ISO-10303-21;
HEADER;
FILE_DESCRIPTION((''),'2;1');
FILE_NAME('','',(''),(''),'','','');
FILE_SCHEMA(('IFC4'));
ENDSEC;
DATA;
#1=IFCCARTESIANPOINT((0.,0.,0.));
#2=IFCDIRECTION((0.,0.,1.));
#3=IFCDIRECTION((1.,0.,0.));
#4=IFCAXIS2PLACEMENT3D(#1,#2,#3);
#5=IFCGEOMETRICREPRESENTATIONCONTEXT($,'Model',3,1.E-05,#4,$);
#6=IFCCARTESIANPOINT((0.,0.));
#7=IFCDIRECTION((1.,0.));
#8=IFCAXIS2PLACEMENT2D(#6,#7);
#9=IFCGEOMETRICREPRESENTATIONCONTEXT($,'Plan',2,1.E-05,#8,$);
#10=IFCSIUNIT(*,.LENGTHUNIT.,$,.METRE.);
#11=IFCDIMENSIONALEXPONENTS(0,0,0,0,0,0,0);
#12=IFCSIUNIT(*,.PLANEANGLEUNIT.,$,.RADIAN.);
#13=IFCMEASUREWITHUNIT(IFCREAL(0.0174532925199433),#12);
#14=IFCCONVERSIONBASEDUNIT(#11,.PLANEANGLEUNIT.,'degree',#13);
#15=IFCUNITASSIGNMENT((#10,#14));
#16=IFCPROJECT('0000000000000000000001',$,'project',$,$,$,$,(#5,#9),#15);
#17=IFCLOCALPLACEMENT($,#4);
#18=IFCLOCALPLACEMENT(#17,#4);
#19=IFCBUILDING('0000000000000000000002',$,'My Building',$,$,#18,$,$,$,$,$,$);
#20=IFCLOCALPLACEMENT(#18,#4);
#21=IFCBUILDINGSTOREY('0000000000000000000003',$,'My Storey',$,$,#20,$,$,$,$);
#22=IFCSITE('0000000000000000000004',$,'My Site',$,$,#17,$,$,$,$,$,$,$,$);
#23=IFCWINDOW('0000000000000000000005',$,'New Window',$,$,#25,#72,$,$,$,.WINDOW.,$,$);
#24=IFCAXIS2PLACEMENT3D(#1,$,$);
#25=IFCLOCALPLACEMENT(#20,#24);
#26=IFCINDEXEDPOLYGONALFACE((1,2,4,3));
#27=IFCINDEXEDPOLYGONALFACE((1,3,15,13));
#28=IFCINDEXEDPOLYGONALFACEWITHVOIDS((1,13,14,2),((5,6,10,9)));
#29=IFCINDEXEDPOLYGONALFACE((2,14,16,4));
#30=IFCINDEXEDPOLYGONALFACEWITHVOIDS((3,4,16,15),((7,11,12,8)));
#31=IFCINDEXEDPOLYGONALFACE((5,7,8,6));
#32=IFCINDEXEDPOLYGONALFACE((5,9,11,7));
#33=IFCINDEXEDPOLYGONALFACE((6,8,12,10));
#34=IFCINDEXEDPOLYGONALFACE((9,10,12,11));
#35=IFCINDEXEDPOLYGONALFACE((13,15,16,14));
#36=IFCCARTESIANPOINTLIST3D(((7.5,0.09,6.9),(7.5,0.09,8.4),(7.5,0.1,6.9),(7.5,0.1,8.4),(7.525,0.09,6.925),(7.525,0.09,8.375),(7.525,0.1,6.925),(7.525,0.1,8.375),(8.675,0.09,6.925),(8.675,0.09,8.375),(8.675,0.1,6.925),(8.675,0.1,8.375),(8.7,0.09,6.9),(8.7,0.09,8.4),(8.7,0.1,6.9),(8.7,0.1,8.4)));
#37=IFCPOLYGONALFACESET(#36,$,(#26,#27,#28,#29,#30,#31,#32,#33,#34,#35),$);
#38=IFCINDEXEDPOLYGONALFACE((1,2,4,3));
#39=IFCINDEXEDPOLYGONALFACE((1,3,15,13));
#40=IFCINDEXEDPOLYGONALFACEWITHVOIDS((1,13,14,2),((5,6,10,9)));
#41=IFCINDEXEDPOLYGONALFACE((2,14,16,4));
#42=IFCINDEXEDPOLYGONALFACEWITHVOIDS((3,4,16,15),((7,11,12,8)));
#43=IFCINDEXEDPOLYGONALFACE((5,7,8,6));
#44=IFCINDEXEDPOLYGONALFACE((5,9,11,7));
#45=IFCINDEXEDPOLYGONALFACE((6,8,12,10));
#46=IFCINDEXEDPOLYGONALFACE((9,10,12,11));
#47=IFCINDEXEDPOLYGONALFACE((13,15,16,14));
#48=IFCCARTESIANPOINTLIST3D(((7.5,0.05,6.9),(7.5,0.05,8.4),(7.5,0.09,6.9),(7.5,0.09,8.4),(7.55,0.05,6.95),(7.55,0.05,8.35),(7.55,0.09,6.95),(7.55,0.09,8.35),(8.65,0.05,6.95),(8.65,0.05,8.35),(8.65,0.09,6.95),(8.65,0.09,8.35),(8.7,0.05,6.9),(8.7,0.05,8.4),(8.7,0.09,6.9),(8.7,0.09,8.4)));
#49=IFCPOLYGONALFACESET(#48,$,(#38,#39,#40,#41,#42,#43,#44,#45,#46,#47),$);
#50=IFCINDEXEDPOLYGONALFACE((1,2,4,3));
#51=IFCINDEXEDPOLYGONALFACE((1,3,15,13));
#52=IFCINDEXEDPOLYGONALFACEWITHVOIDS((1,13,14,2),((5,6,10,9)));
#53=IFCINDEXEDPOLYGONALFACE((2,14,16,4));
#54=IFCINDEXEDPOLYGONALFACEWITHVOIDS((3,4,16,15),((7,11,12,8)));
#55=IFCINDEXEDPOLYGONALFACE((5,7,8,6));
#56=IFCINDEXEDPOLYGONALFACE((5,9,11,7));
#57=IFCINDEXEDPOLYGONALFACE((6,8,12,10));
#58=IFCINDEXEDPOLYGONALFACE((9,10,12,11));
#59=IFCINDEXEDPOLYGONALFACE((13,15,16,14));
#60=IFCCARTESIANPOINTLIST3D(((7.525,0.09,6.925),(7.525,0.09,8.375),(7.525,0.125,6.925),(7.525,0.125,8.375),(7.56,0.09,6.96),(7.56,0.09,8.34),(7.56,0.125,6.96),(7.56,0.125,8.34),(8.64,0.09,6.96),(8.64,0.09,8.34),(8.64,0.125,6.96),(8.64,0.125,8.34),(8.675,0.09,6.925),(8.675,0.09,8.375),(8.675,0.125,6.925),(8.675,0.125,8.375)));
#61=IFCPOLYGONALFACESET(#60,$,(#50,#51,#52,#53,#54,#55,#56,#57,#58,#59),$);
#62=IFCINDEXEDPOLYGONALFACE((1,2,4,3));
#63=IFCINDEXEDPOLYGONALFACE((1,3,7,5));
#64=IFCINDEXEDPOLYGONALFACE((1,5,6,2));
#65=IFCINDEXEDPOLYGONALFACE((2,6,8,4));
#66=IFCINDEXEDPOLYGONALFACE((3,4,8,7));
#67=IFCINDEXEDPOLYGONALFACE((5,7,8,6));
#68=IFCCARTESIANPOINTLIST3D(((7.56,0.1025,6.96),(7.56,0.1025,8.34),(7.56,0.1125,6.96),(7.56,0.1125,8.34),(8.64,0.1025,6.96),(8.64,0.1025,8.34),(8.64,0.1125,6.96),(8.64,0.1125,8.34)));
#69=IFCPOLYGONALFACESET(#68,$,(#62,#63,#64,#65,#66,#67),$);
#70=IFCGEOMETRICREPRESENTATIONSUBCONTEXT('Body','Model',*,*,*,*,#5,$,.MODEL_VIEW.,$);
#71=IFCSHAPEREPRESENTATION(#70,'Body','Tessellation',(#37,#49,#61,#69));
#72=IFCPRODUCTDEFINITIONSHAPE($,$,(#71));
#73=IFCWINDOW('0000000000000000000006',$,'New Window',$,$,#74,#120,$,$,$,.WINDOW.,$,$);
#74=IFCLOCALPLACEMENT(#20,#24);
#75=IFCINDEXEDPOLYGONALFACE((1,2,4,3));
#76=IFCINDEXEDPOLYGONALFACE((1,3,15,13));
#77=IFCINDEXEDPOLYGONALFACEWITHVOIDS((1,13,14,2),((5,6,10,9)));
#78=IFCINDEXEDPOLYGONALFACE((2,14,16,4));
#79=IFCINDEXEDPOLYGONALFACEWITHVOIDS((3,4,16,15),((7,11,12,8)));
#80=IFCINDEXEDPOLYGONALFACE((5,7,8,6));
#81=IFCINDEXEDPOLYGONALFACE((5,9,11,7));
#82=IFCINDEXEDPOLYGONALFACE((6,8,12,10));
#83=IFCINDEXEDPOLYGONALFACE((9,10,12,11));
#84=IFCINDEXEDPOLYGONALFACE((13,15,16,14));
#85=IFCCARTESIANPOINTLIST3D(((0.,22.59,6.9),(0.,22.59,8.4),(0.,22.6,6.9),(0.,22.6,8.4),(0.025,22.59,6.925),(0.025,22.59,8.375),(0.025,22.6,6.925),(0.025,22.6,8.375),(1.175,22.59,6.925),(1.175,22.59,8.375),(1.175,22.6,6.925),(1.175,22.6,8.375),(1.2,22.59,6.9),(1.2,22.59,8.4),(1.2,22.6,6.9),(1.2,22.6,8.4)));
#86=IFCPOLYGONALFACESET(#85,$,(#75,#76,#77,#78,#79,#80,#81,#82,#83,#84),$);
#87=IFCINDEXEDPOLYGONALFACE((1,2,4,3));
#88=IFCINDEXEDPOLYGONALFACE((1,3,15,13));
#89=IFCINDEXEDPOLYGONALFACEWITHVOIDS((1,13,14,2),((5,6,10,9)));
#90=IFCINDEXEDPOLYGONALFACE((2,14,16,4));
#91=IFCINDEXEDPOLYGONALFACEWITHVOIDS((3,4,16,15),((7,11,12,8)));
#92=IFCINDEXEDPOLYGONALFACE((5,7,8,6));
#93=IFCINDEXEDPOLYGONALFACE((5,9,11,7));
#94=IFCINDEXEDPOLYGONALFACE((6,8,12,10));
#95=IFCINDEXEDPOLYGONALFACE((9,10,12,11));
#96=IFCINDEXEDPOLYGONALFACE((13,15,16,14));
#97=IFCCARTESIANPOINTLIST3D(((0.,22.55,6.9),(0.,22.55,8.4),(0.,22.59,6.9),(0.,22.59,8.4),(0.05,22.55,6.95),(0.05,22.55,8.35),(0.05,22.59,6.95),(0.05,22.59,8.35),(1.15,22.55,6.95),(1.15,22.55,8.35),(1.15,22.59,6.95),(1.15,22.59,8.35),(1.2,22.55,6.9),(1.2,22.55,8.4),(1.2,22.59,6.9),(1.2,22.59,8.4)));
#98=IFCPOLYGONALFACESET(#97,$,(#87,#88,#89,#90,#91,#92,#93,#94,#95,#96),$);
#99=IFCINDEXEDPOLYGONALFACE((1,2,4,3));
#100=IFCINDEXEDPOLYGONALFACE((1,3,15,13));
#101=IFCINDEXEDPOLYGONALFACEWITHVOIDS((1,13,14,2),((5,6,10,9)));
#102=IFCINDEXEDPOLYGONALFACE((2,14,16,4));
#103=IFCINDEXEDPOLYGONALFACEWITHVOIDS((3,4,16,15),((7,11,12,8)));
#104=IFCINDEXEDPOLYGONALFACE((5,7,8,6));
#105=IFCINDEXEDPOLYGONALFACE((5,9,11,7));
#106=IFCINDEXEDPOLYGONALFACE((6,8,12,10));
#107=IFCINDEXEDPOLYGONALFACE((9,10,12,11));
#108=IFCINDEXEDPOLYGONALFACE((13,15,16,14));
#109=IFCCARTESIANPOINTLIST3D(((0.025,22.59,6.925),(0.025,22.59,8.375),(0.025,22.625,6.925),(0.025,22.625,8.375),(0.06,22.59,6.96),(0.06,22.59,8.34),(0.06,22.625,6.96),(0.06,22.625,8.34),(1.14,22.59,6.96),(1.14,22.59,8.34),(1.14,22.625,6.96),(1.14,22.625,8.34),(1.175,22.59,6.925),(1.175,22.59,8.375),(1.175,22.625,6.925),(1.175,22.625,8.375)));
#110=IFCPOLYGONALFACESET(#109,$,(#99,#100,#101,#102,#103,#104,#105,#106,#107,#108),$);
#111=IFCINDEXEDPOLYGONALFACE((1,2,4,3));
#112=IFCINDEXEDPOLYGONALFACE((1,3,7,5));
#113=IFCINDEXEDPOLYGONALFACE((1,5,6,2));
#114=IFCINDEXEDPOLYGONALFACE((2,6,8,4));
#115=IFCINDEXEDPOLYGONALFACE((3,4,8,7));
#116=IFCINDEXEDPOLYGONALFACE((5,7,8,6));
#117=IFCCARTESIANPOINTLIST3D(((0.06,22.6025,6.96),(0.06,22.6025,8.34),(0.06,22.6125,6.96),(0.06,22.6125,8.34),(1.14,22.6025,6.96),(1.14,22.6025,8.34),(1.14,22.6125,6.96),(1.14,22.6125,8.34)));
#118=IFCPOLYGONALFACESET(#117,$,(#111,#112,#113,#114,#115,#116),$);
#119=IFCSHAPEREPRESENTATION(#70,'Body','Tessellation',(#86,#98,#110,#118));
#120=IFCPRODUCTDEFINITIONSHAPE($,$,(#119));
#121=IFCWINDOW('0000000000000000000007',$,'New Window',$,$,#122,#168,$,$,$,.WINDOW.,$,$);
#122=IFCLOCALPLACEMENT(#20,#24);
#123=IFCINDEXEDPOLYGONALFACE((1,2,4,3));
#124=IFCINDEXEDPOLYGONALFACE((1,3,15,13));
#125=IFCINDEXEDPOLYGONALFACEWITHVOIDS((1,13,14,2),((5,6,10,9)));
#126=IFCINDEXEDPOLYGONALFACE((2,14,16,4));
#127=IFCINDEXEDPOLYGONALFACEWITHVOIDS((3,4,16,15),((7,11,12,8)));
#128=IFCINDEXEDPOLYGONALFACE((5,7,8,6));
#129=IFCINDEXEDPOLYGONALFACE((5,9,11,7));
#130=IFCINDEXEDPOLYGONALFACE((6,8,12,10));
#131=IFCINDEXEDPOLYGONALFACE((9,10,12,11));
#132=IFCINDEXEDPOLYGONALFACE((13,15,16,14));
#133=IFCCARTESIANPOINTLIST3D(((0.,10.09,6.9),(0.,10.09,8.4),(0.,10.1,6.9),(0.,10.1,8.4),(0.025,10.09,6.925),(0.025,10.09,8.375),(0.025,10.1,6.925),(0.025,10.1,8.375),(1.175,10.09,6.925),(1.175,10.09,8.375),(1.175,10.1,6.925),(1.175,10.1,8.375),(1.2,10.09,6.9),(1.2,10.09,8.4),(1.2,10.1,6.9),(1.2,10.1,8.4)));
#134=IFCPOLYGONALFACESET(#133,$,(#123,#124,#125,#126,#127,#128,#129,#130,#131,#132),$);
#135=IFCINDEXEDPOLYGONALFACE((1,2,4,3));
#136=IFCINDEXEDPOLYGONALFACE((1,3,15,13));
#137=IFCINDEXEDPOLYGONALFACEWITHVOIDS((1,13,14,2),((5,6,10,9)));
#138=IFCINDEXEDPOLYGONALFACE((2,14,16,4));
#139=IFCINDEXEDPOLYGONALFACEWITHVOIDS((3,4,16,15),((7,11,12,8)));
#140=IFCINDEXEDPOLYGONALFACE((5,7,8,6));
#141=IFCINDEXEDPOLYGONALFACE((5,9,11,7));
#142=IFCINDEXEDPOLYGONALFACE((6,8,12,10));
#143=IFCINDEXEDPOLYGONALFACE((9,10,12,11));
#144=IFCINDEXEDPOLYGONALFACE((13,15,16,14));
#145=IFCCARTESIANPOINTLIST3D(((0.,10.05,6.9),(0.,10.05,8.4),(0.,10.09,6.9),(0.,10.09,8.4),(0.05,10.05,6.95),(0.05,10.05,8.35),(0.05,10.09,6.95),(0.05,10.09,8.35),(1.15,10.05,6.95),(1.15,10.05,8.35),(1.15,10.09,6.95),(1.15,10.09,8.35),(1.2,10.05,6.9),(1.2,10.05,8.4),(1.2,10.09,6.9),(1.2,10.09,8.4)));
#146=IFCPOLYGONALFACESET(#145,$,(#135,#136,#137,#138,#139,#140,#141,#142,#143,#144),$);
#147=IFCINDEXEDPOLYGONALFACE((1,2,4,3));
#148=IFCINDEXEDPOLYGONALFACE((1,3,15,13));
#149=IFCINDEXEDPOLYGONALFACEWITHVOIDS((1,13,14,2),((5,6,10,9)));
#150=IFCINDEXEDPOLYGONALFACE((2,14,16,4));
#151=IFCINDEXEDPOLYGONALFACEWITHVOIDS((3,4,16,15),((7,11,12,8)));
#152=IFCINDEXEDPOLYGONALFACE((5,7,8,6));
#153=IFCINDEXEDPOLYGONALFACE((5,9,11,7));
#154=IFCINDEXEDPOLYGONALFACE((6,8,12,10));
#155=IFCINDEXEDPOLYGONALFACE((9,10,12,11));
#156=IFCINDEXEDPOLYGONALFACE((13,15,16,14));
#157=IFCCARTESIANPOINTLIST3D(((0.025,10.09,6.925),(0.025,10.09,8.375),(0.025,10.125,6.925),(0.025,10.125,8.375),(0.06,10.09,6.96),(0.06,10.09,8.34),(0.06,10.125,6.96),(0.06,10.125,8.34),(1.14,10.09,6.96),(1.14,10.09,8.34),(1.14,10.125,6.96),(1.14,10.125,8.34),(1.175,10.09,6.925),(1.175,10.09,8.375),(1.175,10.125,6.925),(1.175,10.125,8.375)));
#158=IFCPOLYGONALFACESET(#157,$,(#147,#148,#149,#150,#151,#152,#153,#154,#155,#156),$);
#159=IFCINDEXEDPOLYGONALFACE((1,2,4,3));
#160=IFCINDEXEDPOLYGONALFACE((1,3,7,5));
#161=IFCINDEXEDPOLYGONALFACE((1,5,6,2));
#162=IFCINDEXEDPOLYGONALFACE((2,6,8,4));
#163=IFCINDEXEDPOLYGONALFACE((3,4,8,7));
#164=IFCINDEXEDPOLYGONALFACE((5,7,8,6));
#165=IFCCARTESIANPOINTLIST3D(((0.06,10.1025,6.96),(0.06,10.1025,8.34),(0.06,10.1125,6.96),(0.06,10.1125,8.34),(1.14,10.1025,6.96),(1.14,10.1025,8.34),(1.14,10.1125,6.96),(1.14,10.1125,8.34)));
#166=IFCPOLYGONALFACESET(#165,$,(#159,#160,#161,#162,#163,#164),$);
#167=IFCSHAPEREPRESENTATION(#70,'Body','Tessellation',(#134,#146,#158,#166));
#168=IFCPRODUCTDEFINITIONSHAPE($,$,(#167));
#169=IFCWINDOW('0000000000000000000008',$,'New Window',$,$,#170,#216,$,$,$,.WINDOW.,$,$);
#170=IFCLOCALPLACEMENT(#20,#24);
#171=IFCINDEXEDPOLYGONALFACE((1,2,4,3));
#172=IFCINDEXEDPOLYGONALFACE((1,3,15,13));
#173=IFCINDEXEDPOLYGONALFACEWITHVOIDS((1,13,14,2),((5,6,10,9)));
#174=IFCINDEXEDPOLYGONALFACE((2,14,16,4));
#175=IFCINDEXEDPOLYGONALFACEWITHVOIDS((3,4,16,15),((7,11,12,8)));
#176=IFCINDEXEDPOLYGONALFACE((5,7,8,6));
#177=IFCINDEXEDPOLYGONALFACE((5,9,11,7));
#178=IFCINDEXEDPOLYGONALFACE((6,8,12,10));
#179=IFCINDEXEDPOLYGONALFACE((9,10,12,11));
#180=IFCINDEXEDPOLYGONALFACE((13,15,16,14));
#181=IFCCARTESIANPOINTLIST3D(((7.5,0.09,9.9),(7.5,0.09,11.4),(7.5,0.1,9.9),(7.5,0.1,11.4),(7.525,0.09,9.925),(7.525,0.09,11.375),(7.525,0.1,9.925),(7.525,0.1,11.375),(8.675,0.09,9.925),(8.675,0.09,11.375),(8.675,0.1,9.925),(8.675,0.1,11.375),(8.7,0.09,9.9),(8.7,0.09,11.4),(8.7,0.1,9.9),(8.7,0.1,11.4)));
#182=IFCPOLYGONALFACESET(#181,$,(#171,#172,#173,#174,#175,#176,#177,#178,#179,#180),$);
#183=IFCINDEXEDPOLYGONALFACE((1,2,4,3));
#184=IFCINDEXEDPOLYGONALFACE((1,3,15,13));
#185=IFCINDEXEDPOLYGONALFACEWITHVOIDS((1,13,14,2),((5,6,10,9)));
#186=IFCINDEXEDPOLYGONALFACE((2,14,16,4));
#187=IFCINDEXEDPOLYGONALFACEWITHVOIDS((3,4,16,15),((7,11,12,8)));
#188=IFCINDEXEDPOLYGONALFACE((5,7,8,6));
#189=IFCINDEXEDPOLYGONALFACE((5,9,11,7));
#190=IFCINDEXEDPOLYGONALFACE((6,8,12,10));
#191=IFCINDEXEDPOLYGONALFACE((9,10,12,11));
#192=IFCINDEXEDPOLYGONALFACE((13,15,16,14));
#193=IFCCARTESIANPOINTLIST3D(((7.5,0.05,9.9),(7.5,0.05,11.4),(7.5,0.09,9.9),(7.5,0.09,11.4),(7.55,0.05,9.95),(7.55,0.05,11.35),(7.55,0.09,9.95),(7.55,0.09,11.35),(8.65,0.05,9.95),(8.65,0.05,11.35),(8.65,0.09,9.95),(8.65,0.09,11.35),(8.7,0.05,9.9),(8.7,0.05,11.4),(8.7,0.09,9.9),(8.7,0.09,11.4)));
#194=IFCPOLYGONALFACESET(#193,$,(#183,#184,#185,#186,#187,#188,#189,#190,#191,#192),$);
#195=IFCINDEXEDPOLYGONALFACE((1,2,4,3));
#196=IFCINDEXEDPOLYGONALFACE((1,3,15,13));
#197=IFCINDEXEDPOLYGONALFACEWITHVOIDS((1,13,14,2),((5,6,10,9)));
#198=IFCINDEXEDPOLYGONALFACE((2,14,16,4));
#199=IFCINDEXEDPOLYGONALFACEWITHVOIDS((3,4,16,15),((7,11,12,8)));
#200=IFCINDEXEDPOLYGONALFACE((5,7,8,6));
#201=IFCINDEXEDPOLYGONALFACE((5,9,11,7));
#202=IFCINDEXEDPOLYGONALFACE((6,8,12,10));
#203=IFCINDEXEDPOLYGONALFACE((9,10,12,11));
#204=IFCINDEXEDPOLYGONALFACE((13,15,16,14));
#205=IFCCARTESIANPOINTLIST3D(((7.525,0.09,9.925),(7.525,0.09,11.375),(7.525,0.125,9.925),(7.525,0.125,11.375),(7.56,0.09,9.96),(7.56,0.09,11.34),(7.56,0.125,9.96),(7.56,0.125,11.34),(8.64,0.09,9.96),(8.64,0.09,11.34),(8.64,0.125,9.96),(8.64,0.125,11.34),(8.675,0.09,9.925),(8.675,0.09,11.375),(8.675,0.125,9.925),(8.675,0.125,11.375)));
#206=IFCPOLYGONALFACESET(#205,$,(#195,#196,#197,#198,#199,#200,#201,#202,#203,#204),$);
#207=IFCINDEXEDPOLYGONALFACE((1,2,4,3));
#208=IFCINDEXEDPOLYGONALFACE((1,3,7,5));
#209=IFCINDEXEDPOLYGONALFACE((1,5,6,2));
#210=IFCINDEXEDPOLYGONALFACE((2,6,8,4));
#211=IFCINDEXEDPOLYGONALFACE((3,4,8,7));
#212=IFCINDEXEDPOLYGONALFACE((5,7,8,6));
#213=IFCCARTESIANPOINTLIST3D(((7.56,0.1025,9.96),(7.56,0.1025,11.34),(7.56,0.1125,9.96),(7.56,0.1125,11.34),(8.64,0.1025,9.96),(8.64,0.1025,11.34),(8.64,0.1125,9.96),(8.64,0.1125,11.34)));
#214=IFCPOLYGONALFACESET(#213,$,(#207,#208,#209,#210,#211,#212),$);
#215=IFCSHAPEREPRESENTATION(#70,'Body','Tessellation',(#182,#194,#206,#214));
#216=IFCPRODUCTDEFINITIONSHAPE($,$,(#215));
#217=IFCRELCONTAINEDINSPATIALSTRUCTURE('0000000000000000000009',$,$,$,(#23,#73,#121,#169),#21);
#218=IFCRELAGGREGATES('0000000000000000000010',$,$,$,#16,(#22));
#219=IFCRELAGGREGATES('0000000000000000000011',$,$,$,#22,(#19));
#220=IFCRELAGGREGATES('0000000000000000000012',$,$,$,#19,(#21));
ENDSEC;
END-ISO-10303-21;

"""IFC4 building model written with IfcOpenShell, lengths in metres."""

from ifc_helpers import new_model, entity, si_unit, converted_unit, frame, origin_with_axes, origin_2d_with_axis, place, context, subcontext, project, spatial, line, indexed_curve, outline, extrude, element, save


model = new_model("IFC4")

# Units and contexts
model_context = context("Model", 3, precision=1e-05, world=origin_with_axes())
plan_context = context("Plan", 2, precision=1e-05, world=origin_2d_with_axis())
body_context = subcontext(model_context, "Body", "Model", "MODEL_VIEW")
ifc_project = project(units=[si_unit("LENGTHUNIT", "METRE"), converted_unit("PLANEANGLEUNIT", "degree", entity("IfcReal", 0.0174532925199433), si_unit("PLANEANGLEUNIT", "RADIAN"), dimensions=[0, 0, 0, 0, 0, 0, 0])], contexts=[model_context, plan_context])

# Site, building, storey
site_placement = place(None, origin_with_axes())
site = spatial("IfcSite", under=ifc_project, at=site_placement, Name="My Site")
building_placement = place(site_placement, origin_with_axes())
building = spatial("IfcBuilding", under=site, at=building_placement, Name="My Building")
storey_placement = place(building_placement, origin_with_axes())
storey = spatial("IfcBuildingStorey", under=building, at=storey_placement, Name="My Storey")

# Windows
for number, where, z_axis, x_axis, name in (
    (1, (7.5, 0.0, 6.9), (0.0, 0.0, 1.0), (1.0, 0.0, 0.0), "New Window"),
    (2, (0.0, 22.5, 6.9), (0.0, 0.0, 1.0), (1.0, 0.0, 0.0), "New Window"),
    (3, (0.0, 10.0, 6.9), (0.0, 0.0, 1.0), (1.0, 0.0, 0.0), "New Window"),
    (4, (7.5, 0.0, 9.9), (0.0, 0.0, 1.0), (1.0, 0.0, 0.0), "New Window"),
):
    element("IfcWindow", number, at=place(storey_placement, frame(where, z_axis=z_axis, x_axis=x_axis)), inside=storey, Name=name, PredefinedType="WINDOW", context=body_context, shape_type="SweptSolid", body=[
        extrude(outline(indexed_curve([(0.0, 0.0), (1.2, 0.0), (1.2, 1.5), (0.0, 1.5)], segments=[line(1, 2, 3, 4, 1)]), holes=[indexed_curve([(0.025, 0.025), (1.175, 0.025), (1.175, 1.475), (0.025, 1.475)], segments=[line(1, 2, 3, 4, 1)])]), frame((0.0, 0.09, 0.0), z_axis=(0.0, -1.0, 0.0), x_axis=(1.0, 0.0, 0.0)), (0.0, 0.0, -1.0), 0.01),
        extrude(outline(indexed_curve([(0.0, 0.0), (1.2, 0.0), (1.2, 1.5), (0.0, 1.5)], segments=[line(1, 2, 3, 4, 1)]), holes=[indexed_curve([(0.05, 0.05), (1.15, 0.05), (1.15, 1.45), (0.05, 1.45)], segments=[line(1, 2, 3, 4, 1)])]), frame((0.0, 0.05, 0.0), z_axis=(0.0, -1.0, 0.0), x_axis=(1.0, 0.0, 0.0)), (0.0, 0.0, -1.0), 0.04),
        extrude(outline(indexed_curve([(0.0, 0.0), (1.15, 0.0), (1.15, 1.45), (0.0, 1.45)], segments=[line(1, 2, 3, 4, 1)]), holes=[indexed_curve([(0.035, 0.035), (1.115, 0.035), (1.115, 1.415), (0.035, 1.415)], segments=[line(1, 2, 3, 4, 1)])]), frame((0.025, 0.09, 0.025), z_axis=(0.0, -1.0, 0.0), x_axis=(1.0, 0.0, 0.0)), (0.0, 0.0, -1.0), 0.035),
        extrude(outline(indexed_curve([(0.035, 0.035), (1.115, 0.035), (1.115, 1.415), (0.035, 1.415)], segments=[line(1, 2, 3, 4, 1)])), frame((0.025, 0.1025, 0.025), z_axis=(0.0, -1.0, 0.0), x_axis=(1.0, 0.0, 0.0)), (0.0, 0.0, -1.0), 0.01),
    ])

save(model, "model.ifc")
